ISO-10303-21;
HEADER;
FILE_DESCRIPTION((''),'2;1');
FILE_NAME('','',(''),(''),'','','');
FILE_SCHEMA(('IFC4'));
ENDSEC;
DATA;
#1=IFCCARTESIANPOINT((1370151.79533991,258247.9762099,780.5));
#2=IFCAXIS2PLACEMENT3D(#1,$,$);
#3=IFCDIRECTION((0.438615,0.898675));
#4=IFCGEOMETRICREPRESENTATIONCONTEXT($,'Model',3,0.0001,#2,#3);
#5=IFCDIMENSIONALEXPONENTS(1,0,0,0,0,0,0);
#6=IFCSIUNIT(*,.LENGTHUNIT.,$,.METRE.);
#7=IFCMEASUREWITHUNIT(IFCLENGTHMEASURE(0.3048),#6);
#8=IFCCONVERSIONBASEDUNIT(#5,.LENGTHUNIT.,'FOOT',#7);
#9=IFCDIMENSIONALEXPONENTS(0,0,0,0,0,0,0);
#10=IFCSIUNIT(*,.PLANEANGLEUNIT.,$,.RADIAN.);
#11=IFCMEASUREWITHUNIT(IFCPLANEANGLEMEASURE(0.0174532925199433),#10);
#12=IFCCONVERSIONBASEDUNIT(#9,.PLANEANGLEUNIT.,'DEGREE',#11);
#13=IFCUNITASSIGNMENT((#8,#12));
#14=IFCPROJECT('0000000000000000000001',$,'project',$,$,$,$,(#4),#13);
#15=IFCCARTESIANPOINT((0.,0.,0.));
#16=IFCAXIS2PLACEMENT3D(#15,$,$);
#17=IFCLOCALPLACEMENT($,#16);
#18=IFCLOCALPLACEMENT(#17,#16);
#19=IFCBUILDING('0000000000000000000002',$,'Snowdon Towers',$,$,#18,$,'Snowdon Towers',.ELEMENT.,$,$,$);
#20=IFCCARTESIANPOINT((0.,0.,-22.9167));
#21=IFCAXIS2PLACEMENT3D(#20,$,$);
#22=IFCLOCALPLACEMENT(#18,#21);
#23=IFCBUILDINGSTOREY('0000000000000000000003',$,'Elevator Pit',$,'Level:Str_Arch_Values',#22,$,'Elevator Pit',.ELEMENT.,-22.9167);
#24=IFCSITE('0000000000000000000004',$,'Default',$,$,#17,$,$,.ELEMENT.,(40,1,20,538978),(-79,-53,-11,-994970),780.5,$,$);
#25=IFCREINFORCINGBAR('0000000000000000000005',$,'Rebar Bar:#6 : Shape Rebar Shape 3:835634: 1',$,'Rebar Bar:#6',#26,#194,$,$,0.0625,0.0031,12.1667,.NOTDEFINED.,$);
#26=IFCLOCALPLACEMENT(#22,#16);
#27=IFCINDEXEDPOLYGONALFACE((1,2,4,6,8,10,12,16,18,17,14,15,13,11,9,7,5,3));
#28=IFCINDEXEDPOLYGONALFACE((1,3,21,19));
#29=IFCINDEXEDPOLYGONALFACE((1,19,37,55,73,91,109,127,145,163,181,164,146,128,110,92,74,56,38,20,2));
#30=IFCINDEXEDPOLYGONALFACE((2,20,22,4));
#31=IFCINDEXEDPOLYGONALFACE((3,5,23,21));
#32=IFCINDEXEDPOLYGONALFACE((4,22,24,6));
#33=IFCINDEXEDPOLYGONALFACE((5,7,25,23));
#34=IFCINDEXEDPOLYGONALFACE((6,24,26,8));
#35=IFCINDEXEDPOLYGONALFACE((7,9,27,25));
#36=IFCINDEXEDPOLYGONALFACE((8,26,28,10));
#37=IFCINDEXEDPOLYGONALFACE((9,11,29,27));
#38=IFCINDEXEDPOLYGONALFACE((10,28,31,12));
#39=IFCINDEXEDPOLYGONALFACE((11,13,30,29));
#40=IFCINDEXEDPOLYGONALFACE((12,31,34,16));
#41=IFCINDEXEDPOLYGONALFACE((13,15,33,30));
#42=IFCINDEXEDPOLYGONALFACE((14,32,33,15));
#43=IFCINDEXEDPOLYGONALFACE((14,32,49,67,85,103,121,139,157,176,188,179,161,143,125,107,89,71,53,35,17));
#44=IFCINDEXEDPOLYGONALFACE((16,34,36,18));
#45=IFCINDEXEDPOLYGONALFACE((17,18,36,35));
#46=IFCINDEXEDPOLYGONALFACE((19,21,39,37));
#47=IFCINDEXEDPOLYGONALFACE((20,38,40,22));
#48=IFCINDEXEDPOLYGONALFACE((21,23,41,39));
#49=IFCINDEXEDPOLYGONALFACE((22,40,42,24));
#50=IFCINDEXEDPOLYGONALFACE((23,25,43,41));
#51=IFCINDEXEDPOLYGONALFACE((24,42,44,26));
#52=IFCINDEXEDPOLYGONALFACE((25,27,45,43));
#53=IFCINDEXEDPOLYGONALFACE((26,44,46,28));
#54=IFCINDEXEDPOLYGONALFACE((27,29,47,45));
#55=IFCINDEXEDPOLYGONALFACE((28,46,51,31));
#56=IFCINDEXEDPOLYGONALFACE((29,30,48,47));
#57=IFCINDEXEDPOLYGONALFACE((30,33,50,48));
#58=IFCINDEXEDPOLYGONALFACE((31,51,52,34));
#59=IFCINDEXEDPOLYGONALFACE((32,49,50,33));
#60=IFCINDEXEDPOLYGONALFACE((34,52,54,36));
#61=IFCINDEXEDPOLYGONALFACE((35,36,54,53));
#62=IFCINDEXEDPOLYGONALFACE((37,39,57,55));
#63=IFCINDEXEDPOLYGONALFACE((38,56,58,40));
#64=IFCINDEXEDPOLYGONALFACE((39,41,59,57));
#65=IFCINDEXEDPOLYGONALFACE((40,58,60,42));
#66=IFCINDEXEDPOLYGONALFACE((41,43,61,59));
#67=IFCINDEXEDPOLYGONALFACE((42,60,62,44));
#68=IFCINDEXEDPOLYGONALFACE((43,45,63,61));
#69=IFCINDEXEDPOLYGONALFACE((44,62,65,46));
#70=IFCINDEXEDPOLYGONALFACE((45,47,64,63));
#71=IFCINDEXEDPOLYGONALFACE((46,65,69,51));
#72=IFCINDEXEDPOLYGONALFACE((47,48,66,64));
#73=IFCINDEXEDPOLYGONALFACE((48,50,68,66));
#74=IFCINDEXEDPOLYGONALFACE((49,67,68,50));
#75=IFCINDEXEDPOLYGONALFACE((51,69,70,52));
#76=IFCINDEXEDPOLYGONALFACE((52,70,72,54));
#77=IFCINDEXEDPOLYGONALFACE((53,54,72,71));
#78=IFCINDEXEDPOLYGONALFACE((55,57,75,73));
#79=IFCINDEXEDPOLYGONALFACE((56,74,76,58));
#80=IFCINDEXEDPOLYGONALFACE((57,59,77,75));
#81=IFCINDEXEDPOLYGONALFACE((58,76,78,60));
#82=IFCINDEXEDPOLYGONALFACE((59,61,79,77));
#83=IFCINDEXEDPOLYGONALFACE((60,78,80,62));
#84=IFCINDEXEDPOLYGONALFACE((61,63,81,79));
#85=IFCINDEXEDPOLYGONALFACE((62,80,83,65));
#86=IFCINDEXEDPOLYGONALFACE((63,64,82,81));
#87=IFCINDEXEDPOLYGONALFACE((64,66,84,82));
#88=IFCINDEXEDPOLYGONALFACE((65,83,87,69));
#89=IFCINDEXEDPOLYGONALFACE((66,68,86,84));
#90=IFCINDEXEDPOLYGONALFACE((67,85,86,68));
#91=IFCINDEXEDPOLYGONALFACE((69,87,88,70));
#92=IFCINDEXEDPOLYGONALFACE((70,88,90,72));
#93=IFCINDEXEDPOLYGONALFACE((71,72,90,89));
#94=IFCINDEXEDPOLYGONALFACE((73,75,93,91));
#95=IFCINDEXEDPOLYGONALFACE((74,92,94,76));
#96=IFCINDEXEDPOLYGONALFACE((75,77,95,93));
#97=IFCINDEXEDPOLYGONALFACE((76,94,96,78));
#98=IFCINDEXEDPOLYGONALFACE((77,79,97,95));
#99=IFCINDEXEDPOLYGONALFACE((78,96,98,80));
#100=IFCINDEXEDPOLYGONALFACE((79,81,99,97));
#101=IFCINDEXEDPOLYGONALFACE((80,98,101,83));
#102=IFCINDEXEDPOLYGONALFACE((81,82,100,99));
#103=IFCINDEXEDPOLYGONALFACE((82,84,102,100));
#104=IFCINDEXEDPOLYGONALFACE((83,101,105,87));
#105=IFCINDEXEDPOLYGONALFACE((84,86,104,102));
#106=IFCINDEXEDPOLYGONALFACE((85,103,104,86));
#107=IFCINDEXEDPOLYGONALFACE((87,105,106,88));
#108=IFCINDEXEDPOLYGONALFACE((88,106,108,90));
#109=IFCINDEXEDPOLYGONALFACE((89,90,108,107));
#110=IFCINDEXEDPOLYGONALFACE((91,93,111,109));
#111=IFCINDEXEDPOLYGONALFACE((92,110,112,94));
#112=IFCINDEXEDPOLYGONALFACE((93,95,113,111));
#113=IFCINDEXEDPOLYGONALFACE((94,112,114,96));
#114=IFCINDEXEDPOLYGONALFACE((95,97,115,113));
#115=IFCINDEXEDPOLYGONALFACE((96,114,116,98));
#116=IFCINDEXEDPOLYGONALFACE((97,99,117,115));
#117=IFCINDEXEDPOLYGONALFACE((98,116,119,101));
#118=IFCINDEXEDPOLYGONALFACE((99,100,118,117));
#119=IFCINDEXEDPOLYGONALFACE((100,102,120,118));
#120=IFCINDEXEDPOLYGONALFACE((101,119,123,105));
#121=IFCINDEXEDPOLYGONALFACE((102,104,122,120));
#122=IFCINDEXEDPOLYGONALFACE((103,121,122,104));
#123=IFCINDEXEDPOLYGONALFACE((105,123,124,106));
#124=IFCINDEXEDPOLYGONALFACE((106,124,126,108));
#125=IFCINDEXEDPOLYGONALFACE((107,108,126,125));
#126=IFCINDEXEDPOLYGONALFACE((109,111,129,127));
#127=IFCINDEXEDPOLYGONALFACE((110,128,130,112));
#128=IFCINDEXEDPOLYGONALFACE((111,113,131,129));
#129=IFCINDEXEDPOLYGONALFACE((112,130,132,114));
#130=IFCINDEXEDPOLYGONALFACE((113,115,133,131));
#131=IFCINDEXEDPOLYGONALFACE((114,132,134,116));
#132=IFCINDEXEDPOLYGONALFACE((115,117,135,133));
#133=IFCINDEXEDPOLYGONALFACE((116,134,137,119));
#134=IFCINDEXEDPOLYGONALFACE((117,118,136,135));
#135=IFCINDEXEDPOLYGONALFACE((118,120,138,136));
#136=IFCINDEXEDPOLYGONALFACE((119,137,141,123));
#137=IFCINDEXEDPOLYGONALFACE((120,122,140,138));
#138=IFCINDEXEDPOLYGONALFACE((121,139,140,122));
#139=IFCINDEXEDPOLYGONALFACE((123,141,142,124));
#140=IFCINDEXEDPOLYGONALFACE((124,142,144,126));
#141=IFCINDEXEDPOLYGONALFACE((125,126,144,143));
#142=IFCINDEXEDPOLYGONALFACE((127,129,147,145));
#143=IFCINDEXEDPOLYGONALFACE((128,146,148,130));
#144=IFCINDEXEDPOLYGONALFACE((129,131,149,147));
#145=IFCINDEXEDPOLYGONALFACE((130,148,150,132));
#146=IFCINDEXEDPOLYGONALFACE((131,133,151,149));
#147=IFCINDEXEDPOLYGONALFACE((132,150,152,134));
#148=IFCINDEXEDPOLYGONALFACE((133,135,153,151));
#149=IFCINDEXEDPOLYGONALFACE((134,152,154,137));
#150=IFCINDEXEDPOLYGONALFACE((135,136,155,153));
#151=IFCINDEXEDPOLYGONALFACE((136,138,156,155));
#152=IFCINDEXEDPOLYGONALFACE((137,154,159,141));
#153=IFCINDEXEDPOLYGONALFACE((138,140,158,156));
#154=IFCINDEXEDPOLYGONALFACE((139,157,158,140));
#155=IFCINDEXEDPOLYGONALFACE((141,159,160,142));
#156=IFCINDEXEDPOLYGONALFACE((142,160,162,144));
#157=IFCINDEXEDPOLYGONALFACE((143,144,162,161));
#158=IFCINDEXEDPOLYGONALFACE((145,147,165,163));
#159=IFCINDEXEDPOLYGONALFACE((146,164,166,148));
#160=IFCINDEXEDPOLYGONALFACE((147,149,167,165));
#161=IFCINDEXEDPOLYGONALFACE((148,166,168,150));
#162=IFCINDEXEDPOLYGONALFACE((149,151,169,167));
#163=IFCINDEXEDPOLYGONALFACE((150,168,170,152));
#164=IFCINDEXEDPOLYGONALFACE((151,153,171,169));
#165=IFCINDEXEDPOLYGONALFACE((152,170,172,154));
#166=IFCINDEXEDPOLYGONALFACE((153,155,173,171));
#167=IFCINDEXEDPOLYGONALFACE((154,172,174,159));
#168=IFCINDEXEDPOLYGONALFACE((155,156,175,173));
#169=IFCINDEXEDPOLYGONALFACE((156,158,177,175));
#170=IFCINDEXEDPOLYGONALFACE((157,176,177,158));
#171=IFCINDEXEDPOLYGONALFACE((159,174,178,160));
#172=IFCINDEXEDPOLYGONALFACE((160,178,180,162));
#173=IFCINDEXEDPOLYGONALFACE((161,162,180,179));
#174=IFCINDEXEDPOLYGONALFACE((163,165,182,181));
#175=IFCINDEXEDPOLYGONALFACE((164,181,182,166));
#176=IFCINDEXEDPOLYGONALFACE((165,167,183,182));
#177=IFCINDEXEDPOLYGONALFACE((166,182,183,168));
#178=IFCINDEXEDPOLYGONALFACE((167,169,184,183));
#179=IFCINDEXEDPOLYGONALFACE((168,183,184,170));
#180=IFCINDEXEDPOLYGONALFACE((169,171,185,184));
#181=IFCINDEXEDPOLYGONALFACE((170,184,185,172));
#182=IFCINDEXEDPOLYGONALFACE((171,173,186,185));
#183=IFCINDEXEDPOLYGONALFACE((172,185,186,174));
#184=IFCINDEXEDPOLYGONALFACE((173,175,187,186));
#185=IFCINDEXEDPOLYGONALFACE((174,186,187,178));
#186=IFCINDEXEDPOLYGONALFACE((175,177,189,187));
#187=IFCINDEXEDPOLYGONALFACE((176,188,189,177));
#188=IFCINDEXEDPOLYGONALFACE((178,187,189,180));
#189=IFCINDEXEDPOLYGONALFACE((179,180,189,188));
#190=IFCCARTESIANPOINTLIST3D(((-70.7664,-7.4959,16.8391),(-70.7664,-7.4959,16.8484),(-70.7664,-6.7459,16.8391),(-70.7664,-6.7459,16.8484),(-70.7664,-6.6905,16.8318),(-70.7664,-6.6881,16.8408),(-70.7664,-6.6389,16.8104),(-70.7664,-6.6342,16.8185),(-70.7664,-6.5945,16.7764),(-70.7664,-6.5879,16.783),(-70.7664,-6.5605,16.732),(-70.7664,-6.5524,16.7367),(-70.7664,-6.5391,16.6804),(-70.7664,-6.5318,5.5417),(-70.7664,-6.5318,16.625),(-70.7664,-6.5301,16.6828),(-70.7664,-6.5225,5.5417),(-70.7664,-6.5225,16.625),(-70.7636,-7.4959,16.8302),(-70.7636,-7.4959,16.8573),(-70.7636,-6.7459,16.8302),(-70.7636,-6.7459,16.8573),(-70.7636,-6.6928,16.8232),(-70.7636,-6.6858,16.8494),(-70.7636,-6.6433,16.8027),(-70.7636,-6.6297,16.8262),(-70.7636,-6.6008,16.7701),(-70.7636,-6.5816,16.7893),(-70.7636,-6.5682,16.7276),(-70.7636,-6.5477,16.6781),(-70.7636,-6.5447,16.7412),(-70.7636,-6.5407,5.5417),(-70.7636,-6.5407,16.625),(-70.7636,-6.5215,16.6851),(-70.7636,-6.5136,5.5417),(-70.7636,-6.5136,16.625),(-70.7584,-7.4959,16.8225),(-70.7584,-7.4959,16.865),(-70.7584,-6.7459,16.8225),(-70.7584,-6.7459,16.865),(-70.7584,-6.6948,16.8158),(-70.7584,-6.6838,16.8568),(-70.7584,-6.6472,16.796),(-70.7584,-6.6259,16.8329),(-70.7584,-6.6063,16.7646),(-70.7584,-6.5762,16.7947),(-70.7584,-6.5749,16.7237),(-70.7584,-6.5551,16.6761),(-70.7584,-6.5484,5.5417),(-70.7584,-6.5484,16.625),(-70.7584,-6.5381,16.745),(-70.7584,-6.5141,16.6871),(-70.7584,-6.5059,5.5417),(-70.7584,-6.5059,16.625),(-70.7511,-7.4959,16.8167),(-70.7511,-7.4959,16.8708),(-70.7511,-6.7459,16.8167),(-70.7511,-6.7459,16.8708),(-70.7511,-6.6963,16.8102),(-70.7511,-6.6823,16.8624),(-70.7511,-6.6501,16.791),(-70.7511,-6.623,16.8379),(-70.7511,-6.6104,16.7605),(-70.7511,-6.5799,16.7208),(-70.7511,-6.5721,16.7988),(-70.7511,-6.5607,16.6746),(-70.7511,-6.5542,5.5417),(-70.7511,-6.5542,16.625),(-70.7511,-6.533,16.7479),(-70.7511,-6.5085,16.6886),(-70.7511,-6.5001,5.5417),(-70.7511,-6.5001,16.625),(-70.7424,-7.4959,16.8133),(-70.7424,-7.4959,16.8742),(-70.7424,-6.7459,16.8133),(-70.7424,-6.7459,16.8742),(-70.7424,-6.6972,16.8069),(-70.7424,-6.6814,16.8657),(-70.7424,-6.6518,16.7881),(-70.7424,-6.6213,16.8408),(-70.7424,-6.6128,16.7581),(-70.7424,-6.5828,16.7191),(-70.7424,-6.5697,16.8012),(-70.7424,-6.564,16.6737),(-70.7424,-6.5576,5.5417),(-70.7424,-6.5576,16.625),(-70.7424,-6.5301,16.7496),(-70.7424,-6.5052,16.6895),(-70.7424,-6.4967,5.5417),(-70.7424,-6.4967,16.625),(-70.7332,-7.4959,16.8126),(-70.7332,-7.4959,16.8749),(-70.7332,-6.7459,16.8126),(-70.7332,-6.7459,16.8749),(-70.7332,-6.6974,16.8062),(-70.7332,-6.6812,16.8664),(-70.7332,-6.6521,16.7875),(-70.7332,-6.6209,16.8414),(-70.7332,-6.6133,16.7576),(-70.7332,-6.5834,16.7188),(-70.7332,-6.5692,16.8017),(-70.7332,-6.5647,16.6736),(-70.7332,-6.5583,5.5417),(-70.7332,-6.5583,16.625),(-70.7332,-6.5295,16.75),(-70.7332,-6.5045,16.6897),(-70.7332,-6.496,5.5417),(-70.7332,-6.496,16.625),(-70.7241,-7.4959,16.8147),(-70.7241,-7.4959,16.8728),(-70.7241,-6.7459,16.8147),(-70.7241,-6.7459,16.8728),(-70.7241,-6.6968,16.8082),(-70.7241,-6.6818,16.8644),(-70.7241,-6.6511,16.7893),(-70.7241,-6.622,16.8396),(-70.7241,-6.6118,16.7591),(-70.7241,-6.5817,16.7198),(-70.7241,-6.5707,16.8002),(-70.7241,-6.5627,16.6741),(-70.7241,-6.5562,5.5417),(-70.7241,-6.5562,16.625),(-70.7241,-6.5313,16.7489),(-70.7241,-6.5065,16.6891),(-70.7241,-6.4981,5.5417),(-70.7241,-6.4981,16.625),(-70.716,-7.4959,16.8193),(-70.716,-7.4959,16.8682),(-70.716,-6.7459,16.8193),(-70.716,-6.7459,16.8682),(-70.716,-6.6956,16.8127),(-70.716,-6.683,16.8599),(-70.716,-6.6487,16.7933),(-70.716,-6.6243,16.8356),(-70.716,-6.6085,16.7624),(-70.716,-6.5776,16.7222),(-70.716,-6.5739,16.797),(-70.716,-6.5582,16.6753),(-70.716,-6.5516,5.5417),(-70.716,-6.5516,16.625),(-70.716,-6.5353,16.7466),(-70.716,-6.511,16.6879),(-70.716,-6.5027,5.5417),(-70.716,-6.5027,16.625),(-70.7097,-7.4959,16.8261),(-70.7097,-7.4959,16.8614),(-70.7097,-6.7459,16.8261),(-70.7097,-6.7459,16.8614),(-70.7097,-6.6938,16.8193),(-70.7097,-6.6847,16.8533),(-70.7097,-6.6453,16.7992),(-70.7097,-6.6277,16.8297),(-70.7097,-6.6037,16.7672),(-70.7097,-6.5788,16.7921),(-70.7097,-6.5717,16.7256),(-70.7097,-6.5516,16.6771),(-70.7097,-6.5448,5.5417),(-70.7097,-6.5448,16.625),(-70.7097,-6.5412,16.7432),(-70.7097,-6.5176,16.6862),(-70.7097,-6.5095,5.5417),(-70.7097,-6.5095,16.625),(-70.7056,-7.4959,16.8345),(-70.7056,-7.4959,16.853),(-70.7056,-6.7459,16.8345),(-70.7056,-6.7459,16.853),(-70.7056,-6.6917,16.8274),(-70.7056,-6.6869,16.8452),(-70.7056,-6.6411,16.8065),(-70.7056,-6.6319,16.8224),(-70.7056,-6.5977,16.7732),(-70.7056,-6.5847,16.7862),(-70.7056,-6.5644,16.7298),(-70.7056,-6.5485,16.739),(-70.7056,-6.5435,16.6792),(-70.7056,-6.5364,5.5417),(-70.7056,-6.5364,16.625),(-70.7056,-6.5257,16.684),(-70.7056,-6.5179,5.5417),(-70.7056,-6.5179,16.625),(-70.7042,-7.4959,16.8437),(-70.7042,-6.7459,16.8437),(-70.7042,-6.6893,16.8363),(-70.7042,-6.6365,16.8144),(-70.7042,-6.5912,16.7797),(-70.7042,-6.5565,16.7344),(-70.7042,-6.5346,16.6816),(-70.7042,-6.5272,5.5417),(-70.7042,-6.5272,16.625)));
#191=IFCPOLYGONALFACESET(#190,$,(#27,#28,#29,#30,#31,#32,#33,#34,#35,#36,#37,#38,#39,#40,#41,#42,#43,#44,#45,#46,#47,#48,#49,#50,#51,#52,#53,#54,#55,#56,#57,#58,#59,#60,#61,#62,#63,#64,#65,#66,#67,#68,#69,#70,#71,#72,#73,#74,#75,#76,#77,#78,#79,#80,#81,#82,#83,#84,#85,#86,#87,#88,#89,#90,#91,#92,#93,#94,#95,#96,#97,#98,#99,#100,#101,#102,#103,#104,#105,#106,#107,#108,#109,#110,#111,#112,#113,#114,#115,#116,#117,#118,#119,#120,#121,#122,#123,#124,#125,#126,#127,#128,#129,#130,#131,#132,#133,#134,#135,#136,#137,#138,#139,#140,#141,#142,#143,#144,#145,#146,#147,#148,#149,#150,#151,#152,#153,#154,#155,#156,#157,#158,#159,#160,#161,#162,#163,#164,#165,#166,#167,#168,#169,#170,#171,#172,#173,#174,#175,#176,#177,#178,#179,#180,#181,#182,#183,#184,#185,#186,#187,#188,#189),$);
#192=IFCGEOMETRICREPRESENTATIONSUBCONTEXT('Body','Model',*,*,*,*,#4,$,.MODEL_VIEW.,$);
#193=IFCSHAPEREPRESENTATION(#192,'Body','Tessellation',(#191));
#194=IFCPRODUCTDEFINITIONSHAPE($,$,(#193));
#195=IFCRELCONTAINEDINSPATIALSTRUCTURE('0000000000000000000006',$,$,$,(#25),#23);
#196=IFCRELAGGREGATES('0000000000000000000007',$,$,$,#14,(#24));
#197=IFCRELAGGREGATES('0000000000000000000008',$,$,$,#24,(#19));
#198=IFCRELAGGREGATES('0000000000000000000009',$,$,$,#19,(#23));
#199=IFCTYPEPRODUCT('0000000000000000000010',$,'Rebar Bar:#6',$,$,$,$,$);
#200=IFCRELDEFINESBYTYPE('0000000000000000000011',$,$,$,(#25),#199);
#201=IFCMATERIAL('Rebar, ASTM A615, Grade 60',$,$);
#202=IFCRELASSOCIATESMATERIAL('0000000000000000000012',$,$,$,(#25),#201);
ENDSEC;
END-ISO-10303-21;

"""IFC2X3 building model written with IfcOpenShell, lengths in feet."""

from ifc_helpers import new_model, entity, si_unit, converted_unit, direction, frame, origin, place, context, subcontext, project, spatial, material, type_object, element, save


model = new_model("IFC2X3")

# Units and contexts
model_context = context("Model", 3, precision=0.0001, world=frame((1370151.79533991, 258247.9762099, 780.5)), true_north=direction((0.438615, 0.898675)))
body_context = subcontext(model_context, "Body", "Model", "MODEL_VIEW")
ifc_project = project(units=[converted_unit("LENGTHUNIT", "FOOT", entity("IfcLengthMeasure", 0.3048), si_unit("LENGTHUNIT", "METRE"), dimensions=[1, 0, 0, 0, 0, 0, 0]), converted_unit("PLANEANGLEUNIT", "DEGREE", entity("IfcPlaneAngleMeasure", 0.0174532925199433), si_unit("PLANEANGLEUNIT", "RADIAN"), dimensions=[0, 0, 0, 0, 0, 0, 0])], contexts=[model_context])

# Site, building, storey
site_placement = place(None, origin())
site = spatial("IfcSite", under=ifc_project, at=site_placement, Name="Default", CompositionType="ELEMENT", RefLatitude=(40, 1, 20, 538978), RefLongitude=(-79, -53, -11, -994970), RefElevation=780.5)
building_placement = place(site_placement, origin())
building = spatial("IfcBuilding", under=site, at=building_placement, Name="Snowdon Towers", LongName="Snowdon Towers", CompositionType="ELEMENT")
storey_placement = place(building_placement, frame((0.0, 0.0, -22.9167)))
storey = spatial("IfcBuildingStorey", under=building, at=storey_placement, Name="Elevator Pit", ObjectType="Level:Str_Arch_Values", LongName="Elevator Pit", CompositionType="ELEMENT", Elevation=-22.9167)

# Reinforcing bar
ifc_material_1 = material(Name="Rebar, ASTM A615, Grade 60")
type_product = type_object("IfcTypeProduct", Name="Rebar Bar:#6")
reinforcing_bar_1_placement = place(storey_placement, origin())
element("IfcReinforcingBar", 1, at=reinforcing_bar_1_placement, inside=storey, type_object=type_product, material=ifc_material_1, Name="Rebar Bar:#6 : Shape Rebar Shape 3:835634: 1", ObjectType="Rebar Bar:#6", BarLength=12.1667, BarRole="NOTDEFINED", CrossSectionArea=0.0031, NominalDiameter=0.0625, context=body_context, shape_type="AdvancedSweptSolid", body=[
    entity("IfcSweptDiskSolid", entity("IfcCompositeCurve", [entity("IfcCompositeCurveSegment", "CONTINUOUS", True, entity("IfcPolyline", [entity("IfcCartesianPoint", [-70.7355, -6.5272, 5.5417]), entity("IfcCartesianPoint", [-70.7355, -6.5272, 16.625])])), entity("IfcCompositeCurveSegment", "CONTINUOUS", True, entity("IfcTrimmedCurve", entity("IfcCircle", entity("IfcAxis2Placement3D", entity("IfcCartesianPoint", [-70.7355, -6.7459, 16.625]), entity("IfcDirection", [1.0, 0.0, 0.0]), entity("IfcDirection", [0.0, 0.0, 1.0])), 0.2188), [entity("IfcParameterValue", 270.0)], [entity("IfcParameterValue", 360.0)], True, "PARAMETER")), entity("IfcCompositeCurveSegment", "CONTINUOUS", True, entity("IfcPolyline", [entity("IfcCartesianPoint", [-70.7355, -6.7459, 16.8437]), entity("IfcCartesianPoint", [-70.7355, -7.4959, 16.8437])]))], False), 0.0312, None, 0.0, 92.0),
])

save(model, "model.ifc")
